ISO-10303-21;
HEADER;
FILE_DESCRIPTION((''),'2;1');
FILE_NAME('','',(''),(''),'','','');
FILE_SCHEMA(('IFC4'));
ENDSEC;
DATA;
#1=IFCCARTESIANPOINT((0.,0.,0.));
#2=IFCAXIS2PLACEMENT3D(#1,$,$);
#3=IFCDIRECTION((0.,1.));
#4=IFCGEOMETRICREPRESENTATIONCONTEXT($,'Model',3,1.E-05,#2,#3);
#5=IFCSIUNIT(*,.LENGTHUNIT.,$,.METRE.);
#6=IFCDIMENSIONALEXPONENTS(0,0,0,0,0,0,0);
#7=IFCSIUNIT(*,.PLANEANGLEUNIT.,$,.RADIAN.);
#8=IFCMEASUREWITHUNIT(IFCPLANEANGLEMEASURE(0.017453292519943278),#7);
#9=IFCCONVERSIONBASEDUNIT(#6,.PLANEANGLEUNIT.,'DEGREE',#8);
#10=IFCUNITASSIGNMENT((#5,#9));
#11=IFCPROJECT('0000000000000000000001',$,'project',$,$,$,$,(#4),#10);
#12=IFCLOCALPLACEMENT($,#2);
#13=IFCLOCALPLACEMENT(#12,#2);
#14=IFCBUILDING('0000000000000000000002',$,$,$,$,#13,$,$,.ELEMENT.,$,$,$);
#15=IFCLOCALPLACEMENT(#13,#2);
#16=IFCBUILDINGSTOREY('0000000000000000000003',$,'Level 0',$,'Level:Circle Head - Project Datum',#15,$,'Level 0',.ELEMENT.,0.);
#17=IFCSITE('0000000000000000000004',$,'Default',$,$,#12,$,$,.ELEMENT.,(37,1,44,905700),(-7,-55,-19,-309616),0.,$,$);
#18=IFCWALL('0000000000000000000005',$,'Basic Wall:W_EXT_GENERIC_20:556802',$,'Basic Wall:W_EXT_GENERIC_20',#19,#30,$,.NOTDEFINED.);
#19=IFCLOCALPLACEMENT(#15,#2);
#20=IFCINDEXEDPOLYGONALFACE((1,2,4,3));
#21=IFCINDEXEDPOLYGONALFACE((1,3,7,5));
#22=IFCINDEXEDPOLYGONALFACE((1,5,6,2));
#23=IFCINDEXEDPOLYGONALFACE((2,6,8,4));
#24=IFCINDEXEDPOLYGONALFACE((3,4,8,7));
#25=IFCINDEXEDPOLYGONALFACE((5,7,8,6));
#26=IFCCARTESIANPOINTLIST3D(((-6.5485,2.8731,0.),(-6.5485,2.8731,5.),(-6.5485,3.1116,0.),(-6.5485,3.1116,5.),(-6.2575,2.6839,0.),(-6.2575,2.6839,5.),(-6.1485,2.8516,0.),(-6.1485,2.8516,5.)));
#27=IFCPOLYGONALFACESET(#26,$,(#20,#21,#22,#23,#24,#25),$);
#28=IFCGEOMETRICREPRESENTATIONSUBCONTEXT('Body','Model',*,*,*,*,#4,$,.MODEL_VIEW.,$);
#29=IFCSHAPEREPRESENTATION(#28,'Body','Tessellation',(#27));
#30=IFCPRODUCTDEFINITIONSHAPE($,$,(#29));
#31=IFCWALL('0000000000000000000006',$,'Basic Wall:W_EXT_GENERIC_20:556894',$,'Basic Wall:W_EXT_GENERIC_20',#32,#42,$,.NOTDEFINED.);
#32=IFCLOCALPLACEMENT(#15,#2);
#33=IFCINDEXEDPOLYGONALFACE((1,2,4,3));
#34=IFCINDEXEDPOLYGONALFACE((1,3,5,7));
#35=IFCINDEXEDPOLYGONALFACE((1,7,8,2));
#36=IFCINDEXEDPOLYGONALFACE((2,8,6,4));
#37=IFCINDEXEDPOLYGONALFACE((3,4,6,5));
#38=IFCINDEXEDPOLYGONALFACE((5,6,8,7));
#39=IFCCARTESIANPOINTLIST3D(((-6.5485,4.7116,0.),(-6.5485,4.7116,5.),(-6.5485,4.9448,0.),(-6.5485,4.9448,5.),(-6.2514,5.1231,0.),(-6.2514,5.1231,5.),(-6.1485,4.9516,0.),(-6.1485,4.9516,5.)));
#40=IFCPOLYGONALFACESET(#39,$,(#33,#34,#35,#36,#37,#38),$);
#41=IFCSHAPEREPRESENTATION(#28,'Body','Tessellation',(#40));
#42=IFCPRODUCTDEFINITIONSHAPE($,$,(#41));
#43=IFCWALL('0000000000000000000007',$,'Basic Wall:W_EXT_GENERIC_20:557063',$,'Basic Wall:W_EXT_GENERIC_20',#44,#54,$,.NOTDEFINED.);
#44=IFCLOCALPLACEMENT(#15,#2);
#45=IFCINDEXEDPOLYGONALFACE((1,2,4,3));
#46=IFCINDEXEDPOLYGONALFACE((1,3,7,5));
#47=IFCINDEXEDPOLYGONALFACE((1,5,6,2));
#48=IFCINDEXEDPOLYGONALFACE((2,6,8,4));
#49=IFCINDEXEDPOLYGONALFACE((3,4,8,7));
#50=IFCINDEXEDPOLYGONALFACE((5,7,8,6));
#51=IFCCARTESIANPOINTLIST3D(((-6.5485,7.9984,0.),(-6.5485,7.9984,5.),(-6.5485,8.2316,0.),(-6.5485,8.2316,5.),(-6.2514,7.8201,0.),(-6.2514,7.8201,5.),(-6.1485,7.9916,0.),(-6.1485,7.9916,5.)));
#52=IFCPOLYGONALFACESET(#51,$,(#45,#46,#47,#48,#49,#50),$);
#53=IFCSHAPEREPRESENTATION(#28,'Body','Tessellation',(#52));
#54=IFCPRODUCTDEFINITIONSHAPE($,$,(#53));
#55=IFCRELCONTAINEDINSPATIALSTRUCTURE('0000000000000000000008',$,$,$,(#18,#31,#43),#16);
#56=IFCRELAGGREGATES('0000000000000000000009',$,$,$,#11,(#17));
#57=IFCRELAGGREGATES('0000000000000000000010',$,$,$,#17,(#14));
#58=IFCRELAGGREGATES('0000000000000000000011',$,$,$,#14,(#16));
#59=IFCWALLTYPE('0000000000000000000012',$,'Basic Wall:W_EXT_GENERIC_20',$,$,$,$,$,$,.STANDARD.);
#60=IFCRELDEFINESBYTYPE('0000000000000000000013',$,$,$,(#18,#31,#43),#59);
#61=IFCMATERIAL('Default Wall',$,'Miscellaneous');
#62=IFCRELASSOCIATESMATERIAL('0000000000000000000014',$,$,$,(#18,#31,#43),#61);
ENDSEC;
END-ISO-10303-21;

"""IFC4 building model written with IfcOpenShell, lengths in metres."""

from ifc_helpers import new_model, entity, si_unit, converted_unit, direction, frame, origin, place, context, subcontext, project, spatial, indexed_curve, outline, extrude, material, type_object, element, save


model = new_model("IFC4")

# Units and contexts
model_context = context("Model", 3, precision=1e-05, world=origin(), true_north=direction((0.0, 1.0)))
body_context = subcontext(model_context, "Body", "Model", "MODEL_VIEW")
ifc_project = project(units=[si_unit("LENGTHUNIT", "METRE"), converted_unit("PLANEANGLEUNIT", "DEGREE", entity("IfcPlaneAngleMeasure", 0.017453292519943278), si_unit("PLANEANGLEUNIT", "RADIAN"), dimensions=[0, 0, 0, 0, 0, 0, 0])], contexts=[model_context])

# Site, building, storey
site_placement = place(None, origin())
site = spatial("IfcSite", under=ifc_project, at=site_placement, Name="Default", CompositionType="ELEMENT", RefLatitude=(37, 1, 44, 905700), RefLongitude=(-7, -55, -19, -309616), RefElevation=0.0)
building_placement = place(site_placement, origin())
building = spatial("IfcBuilding", under=site, at=building_placement, CompositionType="ELEMENT")
storey_placement = place(building_placement, origin())
storey = spatial("IfcBuildingStorey", under=building, at=storey_placement, Name="Level 0", ObjectType="Level:Circle Head - Project Datum", LongName="Level 0", CompositionType="ELEMENT", Elevation=0.0)

# Walls
ifc_material_1 = material(Name="Default Wall", Category="Miscellaneous")
wall_type_1 = type_object("IfcWallType", Name="Basic Wall:W_EXT_GENERIC_20", PredefinedType="STANDARD")
wall_1_placement = place(storey_placement, frame((-6.203, 2.7677, 0.0), z_axis=(0.0, 0.0, 1.0), x_axis=(-0.838444, 0.544988, 0.0)))
element("IfcWall", 1, at=wall_1_placement, inside=storey, type_object=wall_type_1, material=ifc_material_1, Name="Basic Wall:W_EXT_GENERIC_20:556802", ObjectType="Basic Wall:W_EXT_GENERIC_20", PredefinedType="NOTDEFINED", context=body_context, shape_type="SweptSolid", body=[
    extrude(outline(indexed_curve([(0.4771, -0.1), (0.3471, 0.1), (0.0, 0.1), (0.0, -0.1), (0.4771, -0.1)], self_intersect=False)), origin(), (0.0, 0.0, 1.0), 5.0),
])
wall_2_placement = place(storey_placement, frame((-6.1999, 5.0373, 0.0), z_axis=(0.0, 0.0, 1.0), x_axis=(-0.857493, -0.514496, 0.0)))
element("IfcWall", 2, at=wall_2_placement, inside=storey, type_object=wall_type_1, material=ifc_material_1, Name="Basic Wall:W_EXT_GENERIC_20:556894", ObjectType="Basic Wall:W_EXT_GENERIC_20", PredefinedType="NOTDEFINED", context=body_context, shape_type="SweptSolid", body=[
    extrude(outline(indexed_curve([(0.3465, -0.1), (0.4665, 0.1), (0.0, 0.1), (0.0, -0.1), (0.3465, -0.1)], self_intersect=False)), origin(), (0.0, 0.0, 1.0), 5.0),
])
wall_3_placement = place(storey_placement, frame((-6.1999, 7.9058, 0.0), z_axis=(0.0, 0.0, 1.0), x_axis=(-0.857493, 0.514496, 0.0)))
element("IfcWall", 3, at=wall_3_placement, inside=storey, type_object=wall_type_1, material=ifc_material_1, Name="Basic Wall:W_EXT_GENERIC_20:557063", ObjectType="Basic Wall:W_EXT_GENERIC_20", PredefinedType="NOTDEFINED", context=body_context, shape_type="SweptSolid", body=[
    extrude(outline(indexed_curve([(0.4665, -0.1), (0.3465, 0.1), (0.0, 0.1), (0.0, -0.1), (0.4665, -0.1)], self_intersect=False)), origin(), (0.0, 0.0, 1.0), 5.0),
])

save(model, "model.ifc")
